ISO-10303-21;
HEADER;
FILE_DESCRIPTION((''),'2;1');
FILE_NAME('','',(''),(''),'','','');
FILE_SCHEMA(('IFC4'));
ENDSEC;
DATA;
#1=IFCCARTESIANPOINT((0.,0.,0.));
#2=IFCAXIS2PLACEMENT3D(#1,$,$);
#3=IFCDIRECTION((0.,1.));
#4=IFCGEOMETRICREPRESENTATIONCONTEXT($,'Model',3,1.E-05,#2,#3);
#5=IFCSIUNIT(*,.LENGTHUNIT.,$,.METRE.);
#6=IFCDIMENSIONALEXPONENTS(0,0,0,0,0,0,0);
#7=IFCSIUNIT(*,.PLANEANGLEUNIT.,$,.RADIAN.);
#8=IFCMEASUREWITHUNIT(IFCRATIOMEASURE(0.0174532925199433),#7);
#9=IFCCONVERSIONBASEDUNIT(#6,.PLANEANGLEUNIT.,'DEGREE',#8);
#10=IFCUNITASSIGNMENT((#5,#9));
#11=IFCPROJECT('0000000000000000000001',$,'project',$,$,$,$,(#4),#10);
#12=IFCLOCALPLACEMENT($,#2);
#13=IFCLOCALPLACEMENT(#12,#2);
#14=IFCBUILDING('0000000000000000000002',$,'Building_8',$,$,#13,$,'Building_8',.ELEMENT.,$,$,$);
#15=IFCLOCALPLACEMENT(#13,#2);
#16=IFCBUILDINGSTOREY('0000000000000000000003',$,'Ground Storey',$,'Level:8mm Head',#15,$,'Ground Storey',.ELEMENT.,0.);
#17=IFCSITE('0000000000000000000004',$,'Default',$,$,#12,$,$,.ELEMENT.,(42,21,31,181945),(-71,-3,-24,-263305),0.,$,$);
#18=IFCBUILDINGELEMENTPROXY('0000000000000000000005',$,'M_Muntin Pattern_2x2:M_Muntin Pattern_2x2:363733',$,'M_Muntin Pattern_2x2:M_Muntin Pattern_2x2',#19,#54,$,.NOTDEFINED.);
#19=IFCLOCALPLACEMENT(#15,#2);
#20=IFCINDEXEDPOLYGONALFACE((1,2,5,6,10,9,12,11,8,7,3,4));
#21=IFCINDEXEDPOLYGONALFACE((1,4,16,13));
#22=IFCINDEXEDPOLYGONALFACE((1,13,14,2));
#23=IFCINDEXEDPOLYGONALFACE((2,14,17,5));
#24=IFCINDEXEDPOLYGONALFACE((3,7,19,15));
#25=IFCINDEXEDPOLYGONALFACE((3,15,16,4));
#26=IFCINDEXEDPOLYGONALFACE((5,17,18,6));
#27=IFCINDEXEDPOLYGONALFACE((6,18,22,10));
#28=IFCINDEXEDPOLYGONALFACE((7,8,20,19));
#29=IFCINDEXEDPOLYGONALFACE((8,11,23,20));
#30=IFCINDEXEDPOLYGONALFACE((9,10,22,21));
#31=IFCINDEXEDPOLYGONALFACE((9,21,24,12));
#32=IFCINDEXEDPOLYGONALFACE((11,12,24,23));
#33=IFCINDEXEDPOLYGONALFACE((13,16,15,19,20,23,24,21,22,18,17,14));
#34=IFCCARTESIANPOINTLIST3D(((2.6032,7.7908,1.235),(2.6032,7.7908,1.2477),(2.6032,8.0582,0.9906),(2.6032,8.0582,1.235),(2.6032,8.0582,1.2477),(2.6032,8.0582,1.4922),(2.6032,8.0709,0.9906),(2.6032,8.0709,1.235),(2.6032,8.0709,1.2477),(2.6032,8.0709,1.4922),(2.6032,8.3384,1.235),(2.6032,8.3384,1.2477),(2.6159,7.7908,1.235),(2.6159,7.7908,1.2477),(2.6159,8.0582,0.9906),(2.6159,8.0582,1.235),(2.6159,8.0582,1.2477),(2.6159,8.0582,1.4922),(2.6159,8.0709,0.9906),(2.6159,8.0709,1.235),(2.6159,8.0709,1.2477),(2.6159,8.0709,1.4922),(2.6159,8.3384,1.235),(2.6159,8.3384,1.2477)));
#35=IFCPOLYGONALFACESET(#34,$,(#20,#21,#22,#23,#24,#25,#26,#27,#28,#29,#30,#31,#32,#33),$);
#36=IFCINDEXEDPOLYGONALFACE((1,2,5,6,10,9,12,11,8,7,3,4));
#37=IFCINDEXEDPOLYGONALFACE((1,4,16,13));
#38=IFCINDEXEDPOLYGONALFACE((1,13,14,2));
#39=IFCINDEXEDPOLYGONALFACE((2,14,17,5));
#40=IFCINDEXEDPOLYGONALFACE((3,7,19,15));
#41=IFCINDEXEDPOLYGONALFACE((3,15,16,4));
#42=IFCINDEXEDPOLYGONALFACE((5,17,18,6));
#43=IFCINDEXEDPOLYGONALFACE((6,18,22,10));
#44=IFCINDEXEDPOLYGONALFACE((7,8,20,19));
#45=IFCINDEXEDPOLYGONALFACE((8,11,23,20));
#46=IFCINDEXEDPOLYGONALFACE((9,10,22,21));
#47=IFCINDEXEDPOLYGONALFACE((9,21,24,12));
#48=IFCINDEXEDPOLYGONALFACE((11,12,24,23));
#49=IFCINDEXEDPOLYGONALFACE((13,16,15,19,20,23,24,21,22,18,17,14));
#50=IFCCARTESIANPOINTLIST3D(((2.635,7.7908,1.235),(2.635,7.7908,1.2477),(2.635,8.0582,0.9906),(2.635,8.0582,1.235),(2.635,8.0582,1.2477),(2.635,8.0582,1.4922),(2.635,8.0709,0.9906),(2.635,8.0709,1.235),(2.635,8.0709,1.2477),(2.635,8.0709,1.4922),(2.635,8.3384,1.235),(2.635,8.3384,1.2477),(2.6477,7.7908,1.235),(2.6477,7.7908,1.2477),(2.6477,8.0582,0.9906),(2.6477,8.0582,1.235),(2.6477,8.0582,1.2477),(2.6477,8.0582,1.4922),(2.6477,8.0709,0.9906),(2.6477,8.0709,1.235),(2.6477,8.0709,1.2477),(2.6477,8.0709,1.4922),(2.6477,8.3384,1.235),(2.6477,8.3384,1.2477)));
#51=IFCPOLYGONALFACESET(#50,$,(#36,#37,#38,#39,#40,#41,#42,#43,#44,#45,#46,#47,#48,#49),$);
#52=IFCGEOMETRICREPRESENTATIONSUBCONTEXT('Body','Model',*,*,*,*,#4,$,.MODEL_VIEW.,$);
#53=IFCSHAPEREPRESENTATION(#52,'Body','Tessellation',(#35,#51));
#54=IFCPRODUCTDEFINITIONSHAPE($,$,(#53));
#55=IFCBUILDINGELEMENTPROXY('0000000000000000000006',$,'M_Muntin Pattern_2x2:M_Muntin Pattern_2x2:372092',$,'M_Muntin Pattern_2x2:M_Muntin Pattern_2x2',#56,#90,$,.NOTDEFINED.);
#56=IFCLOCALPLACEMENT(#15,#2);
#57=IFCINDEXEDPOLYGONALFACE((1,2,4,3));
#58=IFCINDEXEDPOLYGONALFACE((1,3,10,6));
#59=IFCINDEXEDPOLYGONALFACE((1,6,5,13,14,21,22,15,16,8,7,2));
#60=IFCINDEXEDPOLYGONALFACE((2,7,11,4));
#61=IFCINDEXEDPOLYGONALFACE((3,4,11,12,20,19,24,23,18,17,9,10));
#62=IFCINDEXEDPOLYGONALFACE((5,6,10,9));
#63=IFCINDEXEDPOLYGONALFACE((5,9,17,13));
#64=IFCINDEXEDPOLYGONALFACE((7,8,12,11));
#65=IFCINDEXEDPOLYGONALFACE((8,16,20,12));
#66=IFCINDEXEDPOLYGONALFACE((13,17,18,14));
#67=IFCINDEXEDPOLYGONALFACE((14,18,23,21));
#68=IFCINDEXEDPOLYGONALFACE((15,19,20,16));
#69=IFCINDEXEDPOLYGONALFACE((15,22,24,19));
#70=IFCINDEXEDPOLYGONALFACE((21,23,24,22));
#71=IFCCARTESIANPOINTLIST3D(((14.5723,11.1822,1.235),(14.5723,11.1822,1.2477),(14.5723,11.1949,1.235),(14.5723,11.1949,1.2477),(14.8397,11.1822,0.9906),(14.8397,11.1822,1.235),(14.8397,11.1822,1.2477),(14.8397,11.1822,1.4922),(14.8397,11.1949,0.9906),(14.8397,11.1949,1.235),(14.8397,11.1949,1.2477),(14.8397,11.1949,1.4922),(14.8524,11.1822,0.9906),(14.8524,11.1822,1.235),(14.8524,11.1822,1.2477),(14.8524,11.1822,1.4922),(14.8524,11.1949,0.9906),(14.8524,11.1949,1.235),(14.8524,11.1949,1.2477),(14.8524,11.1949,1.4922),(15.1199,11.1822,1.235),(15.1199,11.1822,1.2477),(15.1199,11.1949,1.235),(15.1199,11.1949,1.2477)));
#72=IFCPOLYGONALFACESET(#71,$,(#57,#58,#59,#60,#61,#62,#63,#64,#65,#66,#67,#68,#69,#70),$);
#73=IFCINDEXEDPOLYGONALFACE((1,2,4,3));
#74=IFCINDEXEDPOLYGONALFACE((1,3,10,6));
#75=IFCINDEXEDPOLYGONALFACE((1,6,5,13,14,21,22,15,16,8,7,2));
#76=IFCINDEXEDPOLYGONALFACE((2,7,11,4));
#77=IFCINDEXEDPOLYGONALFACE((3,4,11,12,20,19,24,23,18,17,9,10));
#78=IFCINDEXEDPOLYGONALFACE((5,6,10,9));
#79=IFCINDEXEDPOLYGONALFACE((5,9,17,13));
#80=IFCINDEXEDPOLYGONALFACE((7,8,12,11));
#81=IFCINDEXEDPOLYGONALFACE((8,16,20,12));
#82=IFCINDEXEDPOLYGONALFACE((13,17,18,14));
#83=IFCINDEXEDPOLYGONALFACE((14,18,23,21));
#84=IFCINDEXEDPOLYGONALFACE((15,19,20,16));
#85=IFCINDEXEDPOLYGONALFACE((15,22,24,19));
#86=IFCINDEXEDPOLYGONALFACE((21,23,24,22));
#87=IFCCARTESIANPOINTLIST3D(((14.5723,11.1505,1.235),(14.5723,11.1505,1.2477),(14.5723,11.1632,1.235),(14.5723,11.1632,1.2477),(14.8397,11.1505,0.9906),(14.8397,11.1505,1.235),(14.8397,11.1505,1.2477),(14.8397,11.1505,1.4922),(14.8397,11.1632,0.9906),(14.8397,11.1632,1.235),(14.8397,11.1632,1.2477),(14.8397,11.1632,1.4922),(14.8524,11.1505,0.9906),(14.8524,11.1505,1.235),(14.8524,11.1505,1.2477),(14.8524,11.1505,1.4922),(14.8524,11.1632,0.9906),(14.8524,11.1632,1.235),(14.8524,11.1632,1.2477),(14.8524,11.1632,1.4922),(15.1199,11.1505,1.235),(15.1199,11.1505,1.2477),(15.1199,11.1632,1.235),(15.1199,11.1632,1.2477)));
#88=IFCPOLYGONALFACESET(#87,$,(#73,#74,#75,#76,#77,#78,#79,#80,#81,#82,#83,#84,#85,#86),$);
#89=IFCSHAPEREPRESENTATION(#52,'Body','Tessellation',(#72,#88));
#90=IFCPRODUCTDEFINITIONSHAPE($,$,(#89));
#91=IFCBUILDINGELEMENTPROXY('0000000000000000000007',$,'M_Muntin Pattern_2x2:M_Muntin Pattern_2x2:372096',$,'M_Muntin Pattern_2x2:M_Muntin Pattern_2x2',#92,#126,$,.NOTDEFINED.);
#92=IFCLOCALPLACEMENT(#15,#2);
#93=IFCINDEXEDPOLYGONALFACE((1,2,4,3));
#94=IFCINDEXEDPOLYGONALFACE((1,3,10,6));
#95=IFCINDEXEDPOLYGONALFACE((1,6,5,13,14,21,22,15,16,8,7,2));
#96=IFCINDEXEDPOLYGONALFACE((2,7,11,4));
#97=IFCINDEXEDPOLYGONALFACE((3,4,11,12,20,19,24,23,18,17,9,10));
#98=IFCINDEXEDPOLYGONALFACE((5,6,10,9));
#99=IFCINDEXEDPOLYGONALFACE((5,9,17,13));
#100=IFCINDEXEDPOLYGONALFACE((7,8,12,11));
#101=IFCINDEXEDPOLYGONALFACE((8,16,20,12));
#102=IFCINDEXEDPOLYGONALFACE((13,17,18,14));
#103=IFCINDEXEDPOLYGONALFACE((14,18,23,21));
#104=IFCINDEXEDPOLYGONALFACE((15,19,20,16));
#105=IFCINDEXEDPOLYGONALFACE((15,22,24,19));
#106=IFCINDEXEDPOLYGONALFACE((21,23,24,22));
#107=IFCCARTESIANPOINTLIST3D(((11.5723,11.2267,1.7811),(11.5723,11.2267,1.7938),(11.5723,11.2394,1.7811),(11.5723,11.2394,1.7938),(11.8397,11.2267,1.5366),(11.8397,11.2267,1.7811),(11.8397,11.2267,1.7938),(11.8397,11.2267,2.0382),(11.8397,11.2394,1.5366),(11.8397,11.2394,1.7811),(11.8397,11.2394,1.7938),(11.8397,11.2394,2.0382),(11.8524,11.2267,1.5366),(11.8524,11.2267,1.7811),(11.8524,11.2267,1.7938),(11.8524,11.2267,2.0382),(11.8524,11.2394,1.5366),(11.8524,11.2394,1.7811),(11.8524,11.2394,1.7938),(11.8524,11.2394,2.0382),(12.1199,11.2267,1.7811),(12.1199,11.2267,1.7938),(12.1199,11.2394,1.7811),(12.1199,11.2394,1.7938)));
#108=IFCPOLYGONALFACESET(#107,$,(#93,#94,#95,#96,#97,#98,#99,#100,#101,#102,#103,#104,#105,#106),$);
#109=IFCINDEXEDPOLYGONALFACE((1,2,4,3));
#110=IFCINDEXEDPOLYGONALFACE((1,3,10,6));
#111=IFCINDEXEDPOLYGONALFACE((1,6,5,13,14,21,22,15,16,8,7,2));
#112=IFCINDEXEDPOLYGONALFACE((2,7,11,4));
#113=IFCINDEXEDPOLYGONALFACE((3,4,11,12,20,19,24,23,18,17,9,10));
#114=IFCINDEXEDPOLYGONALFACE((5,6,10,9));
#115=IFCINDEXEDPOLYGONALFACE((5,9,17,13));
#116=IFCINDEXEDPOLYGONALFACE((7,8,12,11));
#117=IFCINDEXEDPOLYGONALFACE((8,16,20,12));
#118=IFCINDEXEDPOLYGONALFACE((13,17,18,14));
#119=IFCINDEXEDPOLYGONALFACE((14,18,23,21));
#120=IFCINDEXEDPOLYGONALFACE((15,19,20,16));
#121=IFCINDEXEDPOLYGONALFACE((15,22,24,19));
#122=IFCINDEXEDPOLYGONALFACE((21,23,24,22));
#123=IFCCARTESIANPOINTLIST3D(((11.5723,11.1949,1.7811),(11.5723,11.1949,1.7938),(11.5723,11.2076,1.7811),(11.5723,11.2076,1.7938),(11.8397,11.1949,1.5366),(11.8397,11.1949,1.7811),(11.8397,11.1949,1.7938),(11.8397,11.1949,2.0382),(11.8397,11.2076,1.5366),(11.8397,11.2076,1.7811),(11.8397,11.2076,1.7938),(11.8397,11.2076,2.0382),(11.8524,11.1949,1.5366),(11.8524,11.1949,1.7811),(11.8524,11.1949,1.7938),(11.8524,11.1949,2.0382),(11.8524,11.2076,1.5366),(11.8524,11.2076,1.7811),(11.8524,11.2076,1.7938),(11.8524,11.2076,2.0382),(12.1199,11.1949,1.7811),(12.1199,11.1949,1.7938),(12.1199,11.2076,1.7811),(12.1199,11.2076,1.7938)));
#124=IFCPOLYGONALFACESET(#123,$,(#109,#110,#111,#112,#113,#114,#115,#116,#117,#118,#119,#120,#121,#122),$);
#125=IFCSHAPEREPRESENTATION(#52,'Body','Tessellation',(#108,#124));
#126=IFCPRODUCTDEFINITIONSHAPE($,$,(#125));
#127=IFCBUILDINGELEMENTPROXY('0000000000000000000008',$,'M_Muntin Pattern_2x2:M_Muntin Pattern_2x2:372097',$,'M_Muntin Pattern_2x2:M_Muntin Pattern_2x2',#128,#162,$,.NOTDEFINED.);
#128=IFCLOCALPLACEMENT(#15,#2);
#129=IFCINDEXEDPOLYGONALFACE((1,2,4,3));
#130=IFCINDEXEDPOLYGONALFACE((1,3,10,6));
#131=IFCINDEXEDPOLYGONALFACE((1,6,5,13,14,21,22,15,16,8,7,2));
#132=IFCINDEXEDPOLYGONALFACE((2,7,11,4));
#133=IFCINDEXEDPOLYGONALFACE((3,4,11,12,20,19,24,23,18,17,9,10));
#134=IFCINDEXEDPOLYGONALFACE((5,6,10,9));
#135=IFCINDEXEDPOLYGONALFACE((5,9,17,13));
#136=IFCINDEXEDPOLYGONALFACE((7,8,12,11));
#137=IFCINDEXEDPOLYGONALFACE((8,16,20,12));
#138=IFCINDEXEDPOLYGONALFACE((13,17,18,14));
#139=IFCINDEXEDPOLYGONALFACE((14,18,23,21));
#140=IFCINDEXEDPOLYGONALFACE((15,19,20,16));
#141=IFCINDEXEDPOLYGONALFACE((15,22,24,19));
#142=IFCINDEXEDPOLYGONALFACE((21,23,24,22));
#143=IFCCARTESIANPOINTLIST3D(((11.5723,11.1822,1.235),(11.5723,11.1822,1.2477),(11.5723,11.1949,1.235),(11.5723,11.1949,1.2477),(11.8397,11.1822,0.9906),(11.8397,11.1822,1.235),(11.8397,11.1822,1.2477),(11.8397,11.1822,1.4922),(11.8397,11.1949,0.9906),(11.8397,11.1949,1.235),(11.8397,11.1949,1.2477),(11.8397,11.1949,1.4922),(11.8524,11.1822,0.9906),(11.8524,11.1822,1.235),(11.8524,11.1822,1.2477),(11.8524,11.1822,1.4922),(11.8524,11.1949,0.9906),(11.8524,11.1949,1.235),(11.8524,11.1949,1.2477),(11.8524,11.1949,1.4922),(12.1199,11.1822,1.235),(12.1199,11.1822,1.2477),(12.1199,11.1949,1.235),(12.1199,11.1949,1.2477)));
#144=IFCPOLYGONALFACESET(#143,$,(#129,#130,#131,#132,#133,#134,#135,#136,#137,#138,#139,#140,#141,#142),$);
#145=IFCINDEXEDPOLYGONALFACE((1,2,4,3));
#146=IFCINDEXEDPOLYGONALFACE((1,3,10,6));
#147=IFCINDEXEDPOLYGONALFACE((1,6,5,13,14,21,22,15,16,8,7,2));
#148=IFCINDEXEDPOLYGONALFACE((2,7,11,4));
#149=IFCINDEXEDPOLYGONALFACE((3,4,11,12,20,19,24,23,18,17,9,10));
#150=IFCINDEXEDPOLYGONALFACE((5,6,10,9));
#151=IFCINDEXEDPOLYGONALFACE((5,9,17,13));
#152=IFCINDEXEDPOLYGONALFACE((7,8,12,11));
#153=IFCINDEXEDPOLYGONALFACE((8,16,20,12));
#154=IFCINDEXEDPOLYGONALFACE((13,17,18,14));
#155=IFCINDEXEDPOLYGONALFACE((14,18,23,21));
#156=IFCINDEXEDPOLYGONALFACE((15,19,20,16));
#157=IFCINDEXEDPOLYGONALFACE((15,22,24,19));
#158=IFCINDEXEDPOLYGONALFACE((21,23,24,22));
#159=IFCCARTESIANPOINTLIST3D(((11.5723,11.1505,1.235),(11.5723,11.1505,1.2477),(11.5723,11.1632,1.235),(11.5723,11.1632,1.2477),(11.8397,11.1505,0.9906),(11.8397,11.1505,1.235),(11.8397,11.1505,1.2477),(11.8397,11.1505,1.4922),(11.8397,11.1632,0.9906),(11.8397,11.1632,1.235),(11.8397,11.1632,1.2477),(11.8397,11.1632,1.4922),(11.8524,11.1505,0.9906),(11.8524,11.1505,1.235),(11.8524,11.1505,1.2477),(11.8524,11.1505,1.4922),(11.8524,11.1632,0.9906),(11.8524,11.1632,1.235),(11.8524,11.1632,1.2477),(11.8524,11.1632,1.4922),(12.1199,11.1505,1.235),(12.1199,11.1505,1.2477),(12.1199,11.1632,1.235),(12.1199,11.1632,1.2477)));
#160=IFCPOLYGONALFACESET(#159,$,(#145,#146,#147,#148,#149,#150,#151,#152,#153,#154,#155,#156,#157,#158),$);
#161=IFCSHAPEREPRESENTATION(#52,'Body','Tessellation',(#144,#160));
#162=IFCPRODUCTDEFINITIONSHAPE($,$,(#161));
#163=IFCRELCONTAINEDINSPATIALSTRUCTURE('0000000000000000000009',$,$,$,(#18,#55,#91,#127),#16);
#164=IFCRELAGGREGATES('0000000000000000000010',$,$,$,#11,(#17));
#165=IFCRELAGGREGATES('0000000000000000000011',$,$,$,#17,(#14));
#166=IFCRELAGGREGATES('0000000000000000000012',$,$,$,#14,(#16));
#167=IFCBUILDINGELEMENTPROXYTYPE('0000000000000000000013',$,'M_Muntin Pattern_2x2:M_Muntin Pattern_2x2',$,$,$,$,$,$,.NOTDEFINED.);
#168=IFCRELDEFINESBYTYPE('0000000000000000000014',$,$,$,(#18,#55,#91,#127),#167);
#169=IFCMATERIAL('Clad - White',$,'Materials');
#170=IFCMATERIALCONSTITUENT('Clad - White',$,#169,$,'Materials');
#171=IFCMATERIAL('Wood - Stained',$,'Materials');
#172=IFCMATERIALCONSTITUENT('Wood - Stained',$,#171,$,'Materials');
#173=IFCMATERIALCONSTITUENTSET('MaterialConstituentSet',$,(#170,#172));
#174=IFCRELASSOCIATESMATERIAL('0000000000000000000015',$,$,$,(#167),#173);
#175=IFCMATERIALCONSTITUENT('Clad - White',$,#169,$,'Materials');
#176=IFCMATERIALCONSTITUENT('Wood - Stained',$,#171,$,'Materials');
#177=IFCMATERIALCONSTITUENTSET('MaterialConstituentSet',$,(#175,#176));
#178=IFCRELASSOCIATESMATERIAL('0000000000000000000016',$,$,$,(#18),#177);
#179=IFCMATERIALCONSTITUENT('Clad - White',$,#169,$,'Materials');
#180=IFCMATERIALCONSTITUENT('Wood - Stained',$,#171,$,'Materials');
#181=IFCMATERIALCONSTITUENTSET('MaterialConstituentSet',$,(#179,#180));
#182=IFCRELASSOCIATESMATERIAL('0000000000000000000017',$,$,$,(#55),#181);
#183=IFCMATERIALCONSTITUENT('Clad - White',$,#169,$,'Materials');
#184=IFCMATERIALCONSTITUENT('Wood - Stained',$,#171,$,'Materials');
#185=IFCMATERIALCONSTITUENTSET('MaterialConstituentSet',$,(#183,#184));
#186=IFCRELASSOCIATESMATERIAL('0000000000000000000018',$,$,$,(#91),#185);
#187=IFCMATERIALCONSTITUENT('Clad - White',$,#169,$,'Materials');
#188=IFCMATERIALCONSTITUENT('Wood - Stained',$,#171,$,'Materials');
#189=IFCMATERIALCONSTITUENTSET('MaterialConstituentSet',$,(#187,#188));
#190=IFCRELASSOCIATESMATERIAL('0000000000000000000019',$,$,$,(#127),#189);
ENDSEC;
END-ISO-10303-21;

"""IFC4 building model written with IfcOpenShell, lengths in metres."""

from ifc_helpers import new_model, entity, si_unit, converted_unit, direction, frame, origin, place, context, subcontext, project, spatial, indexed_curve, outline, extrude, source, transform, mapped, material, constituent, constituent_set, type_object, type_shapes, element, save


model = new_model("IFC4")

# Units and contexts
model_context = context("Model", 3, precision=1e-05, world=origin(), true_north=direction((0.0, 1.0)))
body_context = subcontext(model_context, "Body", "Model", "MODEL_VIEW")
ifc_project = project(units=[si_unit("LENGTHUNIT", "METRE"), converted_unit("PLANEANGLEUNIT", "DEGREE", entity("IfcRatioMeasure", 0.0174532925199433), si_unit("PLANEANGLEUNIT", "RADIAN"), dimensions=[0, 0, 0, 0, 0, 0, 0])], contexts=[model_context])

# Site, building, storey
site_placement = place(None, origin())
site = spatial("IfcSite", under=ifc_project, at=site_placement, Name="Default", CompositionType="ELEMENT", RefLatitude=(42, 21, 31, 181945), RefLongitude=(-71, -3, -24, -263305), RefElevation=0.0)
building_placement = place(site_placement, origin())
building = spatial("IfcBuilding", under=site, at=building_placement, Name="Building_8", LongName="Building_8", CompositionType="ELEMENT")
storey_placement = place(building_placement, origin())
storey = spatial("IfcBuildingStorey", under=building, at=storey_placement, Name="Ground Storey", ObjectType="Level:8mm Head", LongName="Ground Storey", CompositionType="ELEMENT", Elevation=0.0)

# Building element proxies
ifc_material_1 = material(Name="Clad - White", Category="Materials")
ifc_material_2 = material(Name="Wood - Stained", Category="Materials")
ifc_constituent_1 = constituent(ifc_material_1, Name="Clad - White", Category="Materials")
ifc_constituent_2 = constituent(ifc_material_2, Name="Wood - Stained", Category="Materials")
ifc_constituent_set_1 = constituent_set(constituents=[ifc_constituent_1, ifc_constituent_2], Name="MaterialConstituentSet")
building_element_proxy_type_1 = type_object("IfcBuildingElementProxyType", Name="M_Muntin Pattern_2x2:M_Muntin Pattern_2x2", PredefinedType="NOTDEFINED", material=ifc_constituent_set_1)
shared_shape_1 = source(origin(), body_context, "Body", "SweptSolid", [
    extrude(outline(indexed_curve([(0.0064, -0.0064), (0.2508, -0.0064), (0.2508, 0.0063), (0.0064, 0.0063), (0.0064, 0.2738), (-0.0063, 0.2738), (-0.0063, 0.0063), (-0.2508, 0.0063), (-0.2508, -0.0064), (-0.0063, -0.0064), (-0.0063, -0.2738), (0.0064, -0.2738), (0.0064, -0.0064)], self_intersect=False)), frame((0.0, 0.0095, 0.2508), z_axis=(0.0, 1.0, 0.0), x_axis=(0.0, 0.0, 1.0)), (0.0, 0.0, 1.0), 0.0127),
    extrude(outline(indexed_curve([(0.0064, -0.0064), (0.2508, -0.0064), (0.2508, 0.0063), (0.0064, 0.0063), (0.0064, 0.2738), (-0.0063, 0.2738), (-0.0063, 0.0063), (-0.2508, 0.0063), (-0.2508, -0.0064), (-0.0063, -0.0064), (-0.0063, -0.2738), (0.0064, -0.2738), (0.0064, -0.0064)], self_intersect=False)), frame((0.0, -0.0222, 0.2508), z_axis=(0.0, 1.0, 0.0), x_axis=(0.0, 0.0, 1.0)), (0.0, 0.0, 1.0), 0.0127),
])
type_shapes(building_element_proxy_type_1, [shared_shape_1])
ifc_constituent_3 = constituent(ifc_material_1, Name="Clad - White", Category="Materials")
ifc_constituent_4 = constituent(ifc_material_2, Name="Wood - Stained", Category="Materials")
ifc_constituent_set_2 = constituent_set(constituents=[ifc_constituent_3, ifc_constituent_4], Name="MaterialConstituentSet")
proxy_1_placement = place(storey_placement, frame((2.6255, 8.0646, 0.9906), z_axis=(0.0, 0.0, 1.0), x_axis=(0.0, 1.0, 0.0)))
element("IfcBuildingElementProxy", 1, at=proxy_1_placement, inside=storey, type_object=building_element_proxy_type_1, material=ifc_constituent_set_2, Name="M_Muntin Pattern_2x2:M_Muntin Pattern_2x2:363733", ObjectType="M_Muntin Pattern_2x2:M_Muntin Pattern_2x2", PredefinedType="NOTDEFINED", context=body_context, shape_type="MappedRepresentation", body=[
    mapped(shared_shape_1, transform((0.0, 0.0, 0.0), scale=1.0)),
])
ifc_constituent_5 = constituent(ifc_material_1, Name="Clad - White", Category="Materials")
ifc_constituent_6 = constituent(ifc_material_2, Name="Wood - Stained", Category="Materials")
ifc_constituent_set_3 = constituent_set(constituents=[ifc_constituent_5, ifc_constituent_6], Name="MaterialConstituentSet")
proxy_2_placement = place(storey_placement, frame((14.8461, 11.1727, 0.9906)))
element("IfcBuildingElementProxy", 2, at=proxy_2_placement, inside=storey, type_object=building_element_proxy_type_1, material=ifc_constituent_set_3, Name="M_Muntin Pattern_2x2:M_Muntin Pattern_2x2:372092", ObjectType="M_Muntin Pattern_2x2:M_Muntin Pattern_2x2", PredefinedType="NOTDEFINED", context=body_context, shape_type="MappedRepresentation", body=[
    mapped(shared_shape_1, transform((0.0, 0.0, 0.0), scale=1.0)),
])
ifc_constituent_7 = constituent(ifc_material_1, Name="Clad - White", Category="Materials")
ifc_constituent_8 = constituent(ifc_material_2, Name="Wood - Stained", Category="Materials")
ifc_constituent_set_4 = constituent_set(constituents=[ifc_constituent_7, ifc_constituent_8], Name="MaterialConstituentSet")
proxy_3_placement = place(storey_placement, frame((11.8461, 11.2171, 1.5366)))
element("IfcBuildingElementProxy", 3, at=proxy_3_placement, inside=storey, type_object=building_element_proxy_type_1, material=ifc_constituent_set_4, Name="M_Muntin Pattern_2x2:M_Muntin Pattern_2x2:372096", ObjectType="M_Muntin Pattern_2x2:M_Muntin Pattern_2x2", PredefinedType="NOTDEFINED", context=body_context, shape_type="MappedRepresentation", body=[
    mapped(shared_shape_1, transform((0.0, 0.0, 0.0), scale=1.0)),
])
ifc_constituent_9 = constituent(ifc_material_1, Name="Clad - White", Category="Materials")
ifc_constituent_10 = constituent(ifc_material_2, Name="Wood - Stained", Category="Materials")
ifc_constituent_set_5 = constituent_set(constituents=[ifc_constituent_9, ifc_constituent_10], Name="MaterialConstituentSet")
proxy_4_placement = place(storey_placement, frame((11.8461, 11.1727, 0.9906)))
element("IfcBuildingElementProxy", 4, at=proxy_4_placement, inside=storey, type_object=building_element_proxy_type_1, material=ifc_constituent_set_5, Name="M_Muntin Pattern_2x2:M_Muntin Pattern_2x2:372097", ObjectType="M_Muntin Pattern_2x2:M_Muntin Pattern_2x2", PredefinedType="NOTDEFINED", context=body_context, shape_type="MappedRepresentation", body=[
    mapped(shared_shape_1, transform((0.0, 0.0, 0.0), scale=1.0)),
])

save(model, "model.ifc")
